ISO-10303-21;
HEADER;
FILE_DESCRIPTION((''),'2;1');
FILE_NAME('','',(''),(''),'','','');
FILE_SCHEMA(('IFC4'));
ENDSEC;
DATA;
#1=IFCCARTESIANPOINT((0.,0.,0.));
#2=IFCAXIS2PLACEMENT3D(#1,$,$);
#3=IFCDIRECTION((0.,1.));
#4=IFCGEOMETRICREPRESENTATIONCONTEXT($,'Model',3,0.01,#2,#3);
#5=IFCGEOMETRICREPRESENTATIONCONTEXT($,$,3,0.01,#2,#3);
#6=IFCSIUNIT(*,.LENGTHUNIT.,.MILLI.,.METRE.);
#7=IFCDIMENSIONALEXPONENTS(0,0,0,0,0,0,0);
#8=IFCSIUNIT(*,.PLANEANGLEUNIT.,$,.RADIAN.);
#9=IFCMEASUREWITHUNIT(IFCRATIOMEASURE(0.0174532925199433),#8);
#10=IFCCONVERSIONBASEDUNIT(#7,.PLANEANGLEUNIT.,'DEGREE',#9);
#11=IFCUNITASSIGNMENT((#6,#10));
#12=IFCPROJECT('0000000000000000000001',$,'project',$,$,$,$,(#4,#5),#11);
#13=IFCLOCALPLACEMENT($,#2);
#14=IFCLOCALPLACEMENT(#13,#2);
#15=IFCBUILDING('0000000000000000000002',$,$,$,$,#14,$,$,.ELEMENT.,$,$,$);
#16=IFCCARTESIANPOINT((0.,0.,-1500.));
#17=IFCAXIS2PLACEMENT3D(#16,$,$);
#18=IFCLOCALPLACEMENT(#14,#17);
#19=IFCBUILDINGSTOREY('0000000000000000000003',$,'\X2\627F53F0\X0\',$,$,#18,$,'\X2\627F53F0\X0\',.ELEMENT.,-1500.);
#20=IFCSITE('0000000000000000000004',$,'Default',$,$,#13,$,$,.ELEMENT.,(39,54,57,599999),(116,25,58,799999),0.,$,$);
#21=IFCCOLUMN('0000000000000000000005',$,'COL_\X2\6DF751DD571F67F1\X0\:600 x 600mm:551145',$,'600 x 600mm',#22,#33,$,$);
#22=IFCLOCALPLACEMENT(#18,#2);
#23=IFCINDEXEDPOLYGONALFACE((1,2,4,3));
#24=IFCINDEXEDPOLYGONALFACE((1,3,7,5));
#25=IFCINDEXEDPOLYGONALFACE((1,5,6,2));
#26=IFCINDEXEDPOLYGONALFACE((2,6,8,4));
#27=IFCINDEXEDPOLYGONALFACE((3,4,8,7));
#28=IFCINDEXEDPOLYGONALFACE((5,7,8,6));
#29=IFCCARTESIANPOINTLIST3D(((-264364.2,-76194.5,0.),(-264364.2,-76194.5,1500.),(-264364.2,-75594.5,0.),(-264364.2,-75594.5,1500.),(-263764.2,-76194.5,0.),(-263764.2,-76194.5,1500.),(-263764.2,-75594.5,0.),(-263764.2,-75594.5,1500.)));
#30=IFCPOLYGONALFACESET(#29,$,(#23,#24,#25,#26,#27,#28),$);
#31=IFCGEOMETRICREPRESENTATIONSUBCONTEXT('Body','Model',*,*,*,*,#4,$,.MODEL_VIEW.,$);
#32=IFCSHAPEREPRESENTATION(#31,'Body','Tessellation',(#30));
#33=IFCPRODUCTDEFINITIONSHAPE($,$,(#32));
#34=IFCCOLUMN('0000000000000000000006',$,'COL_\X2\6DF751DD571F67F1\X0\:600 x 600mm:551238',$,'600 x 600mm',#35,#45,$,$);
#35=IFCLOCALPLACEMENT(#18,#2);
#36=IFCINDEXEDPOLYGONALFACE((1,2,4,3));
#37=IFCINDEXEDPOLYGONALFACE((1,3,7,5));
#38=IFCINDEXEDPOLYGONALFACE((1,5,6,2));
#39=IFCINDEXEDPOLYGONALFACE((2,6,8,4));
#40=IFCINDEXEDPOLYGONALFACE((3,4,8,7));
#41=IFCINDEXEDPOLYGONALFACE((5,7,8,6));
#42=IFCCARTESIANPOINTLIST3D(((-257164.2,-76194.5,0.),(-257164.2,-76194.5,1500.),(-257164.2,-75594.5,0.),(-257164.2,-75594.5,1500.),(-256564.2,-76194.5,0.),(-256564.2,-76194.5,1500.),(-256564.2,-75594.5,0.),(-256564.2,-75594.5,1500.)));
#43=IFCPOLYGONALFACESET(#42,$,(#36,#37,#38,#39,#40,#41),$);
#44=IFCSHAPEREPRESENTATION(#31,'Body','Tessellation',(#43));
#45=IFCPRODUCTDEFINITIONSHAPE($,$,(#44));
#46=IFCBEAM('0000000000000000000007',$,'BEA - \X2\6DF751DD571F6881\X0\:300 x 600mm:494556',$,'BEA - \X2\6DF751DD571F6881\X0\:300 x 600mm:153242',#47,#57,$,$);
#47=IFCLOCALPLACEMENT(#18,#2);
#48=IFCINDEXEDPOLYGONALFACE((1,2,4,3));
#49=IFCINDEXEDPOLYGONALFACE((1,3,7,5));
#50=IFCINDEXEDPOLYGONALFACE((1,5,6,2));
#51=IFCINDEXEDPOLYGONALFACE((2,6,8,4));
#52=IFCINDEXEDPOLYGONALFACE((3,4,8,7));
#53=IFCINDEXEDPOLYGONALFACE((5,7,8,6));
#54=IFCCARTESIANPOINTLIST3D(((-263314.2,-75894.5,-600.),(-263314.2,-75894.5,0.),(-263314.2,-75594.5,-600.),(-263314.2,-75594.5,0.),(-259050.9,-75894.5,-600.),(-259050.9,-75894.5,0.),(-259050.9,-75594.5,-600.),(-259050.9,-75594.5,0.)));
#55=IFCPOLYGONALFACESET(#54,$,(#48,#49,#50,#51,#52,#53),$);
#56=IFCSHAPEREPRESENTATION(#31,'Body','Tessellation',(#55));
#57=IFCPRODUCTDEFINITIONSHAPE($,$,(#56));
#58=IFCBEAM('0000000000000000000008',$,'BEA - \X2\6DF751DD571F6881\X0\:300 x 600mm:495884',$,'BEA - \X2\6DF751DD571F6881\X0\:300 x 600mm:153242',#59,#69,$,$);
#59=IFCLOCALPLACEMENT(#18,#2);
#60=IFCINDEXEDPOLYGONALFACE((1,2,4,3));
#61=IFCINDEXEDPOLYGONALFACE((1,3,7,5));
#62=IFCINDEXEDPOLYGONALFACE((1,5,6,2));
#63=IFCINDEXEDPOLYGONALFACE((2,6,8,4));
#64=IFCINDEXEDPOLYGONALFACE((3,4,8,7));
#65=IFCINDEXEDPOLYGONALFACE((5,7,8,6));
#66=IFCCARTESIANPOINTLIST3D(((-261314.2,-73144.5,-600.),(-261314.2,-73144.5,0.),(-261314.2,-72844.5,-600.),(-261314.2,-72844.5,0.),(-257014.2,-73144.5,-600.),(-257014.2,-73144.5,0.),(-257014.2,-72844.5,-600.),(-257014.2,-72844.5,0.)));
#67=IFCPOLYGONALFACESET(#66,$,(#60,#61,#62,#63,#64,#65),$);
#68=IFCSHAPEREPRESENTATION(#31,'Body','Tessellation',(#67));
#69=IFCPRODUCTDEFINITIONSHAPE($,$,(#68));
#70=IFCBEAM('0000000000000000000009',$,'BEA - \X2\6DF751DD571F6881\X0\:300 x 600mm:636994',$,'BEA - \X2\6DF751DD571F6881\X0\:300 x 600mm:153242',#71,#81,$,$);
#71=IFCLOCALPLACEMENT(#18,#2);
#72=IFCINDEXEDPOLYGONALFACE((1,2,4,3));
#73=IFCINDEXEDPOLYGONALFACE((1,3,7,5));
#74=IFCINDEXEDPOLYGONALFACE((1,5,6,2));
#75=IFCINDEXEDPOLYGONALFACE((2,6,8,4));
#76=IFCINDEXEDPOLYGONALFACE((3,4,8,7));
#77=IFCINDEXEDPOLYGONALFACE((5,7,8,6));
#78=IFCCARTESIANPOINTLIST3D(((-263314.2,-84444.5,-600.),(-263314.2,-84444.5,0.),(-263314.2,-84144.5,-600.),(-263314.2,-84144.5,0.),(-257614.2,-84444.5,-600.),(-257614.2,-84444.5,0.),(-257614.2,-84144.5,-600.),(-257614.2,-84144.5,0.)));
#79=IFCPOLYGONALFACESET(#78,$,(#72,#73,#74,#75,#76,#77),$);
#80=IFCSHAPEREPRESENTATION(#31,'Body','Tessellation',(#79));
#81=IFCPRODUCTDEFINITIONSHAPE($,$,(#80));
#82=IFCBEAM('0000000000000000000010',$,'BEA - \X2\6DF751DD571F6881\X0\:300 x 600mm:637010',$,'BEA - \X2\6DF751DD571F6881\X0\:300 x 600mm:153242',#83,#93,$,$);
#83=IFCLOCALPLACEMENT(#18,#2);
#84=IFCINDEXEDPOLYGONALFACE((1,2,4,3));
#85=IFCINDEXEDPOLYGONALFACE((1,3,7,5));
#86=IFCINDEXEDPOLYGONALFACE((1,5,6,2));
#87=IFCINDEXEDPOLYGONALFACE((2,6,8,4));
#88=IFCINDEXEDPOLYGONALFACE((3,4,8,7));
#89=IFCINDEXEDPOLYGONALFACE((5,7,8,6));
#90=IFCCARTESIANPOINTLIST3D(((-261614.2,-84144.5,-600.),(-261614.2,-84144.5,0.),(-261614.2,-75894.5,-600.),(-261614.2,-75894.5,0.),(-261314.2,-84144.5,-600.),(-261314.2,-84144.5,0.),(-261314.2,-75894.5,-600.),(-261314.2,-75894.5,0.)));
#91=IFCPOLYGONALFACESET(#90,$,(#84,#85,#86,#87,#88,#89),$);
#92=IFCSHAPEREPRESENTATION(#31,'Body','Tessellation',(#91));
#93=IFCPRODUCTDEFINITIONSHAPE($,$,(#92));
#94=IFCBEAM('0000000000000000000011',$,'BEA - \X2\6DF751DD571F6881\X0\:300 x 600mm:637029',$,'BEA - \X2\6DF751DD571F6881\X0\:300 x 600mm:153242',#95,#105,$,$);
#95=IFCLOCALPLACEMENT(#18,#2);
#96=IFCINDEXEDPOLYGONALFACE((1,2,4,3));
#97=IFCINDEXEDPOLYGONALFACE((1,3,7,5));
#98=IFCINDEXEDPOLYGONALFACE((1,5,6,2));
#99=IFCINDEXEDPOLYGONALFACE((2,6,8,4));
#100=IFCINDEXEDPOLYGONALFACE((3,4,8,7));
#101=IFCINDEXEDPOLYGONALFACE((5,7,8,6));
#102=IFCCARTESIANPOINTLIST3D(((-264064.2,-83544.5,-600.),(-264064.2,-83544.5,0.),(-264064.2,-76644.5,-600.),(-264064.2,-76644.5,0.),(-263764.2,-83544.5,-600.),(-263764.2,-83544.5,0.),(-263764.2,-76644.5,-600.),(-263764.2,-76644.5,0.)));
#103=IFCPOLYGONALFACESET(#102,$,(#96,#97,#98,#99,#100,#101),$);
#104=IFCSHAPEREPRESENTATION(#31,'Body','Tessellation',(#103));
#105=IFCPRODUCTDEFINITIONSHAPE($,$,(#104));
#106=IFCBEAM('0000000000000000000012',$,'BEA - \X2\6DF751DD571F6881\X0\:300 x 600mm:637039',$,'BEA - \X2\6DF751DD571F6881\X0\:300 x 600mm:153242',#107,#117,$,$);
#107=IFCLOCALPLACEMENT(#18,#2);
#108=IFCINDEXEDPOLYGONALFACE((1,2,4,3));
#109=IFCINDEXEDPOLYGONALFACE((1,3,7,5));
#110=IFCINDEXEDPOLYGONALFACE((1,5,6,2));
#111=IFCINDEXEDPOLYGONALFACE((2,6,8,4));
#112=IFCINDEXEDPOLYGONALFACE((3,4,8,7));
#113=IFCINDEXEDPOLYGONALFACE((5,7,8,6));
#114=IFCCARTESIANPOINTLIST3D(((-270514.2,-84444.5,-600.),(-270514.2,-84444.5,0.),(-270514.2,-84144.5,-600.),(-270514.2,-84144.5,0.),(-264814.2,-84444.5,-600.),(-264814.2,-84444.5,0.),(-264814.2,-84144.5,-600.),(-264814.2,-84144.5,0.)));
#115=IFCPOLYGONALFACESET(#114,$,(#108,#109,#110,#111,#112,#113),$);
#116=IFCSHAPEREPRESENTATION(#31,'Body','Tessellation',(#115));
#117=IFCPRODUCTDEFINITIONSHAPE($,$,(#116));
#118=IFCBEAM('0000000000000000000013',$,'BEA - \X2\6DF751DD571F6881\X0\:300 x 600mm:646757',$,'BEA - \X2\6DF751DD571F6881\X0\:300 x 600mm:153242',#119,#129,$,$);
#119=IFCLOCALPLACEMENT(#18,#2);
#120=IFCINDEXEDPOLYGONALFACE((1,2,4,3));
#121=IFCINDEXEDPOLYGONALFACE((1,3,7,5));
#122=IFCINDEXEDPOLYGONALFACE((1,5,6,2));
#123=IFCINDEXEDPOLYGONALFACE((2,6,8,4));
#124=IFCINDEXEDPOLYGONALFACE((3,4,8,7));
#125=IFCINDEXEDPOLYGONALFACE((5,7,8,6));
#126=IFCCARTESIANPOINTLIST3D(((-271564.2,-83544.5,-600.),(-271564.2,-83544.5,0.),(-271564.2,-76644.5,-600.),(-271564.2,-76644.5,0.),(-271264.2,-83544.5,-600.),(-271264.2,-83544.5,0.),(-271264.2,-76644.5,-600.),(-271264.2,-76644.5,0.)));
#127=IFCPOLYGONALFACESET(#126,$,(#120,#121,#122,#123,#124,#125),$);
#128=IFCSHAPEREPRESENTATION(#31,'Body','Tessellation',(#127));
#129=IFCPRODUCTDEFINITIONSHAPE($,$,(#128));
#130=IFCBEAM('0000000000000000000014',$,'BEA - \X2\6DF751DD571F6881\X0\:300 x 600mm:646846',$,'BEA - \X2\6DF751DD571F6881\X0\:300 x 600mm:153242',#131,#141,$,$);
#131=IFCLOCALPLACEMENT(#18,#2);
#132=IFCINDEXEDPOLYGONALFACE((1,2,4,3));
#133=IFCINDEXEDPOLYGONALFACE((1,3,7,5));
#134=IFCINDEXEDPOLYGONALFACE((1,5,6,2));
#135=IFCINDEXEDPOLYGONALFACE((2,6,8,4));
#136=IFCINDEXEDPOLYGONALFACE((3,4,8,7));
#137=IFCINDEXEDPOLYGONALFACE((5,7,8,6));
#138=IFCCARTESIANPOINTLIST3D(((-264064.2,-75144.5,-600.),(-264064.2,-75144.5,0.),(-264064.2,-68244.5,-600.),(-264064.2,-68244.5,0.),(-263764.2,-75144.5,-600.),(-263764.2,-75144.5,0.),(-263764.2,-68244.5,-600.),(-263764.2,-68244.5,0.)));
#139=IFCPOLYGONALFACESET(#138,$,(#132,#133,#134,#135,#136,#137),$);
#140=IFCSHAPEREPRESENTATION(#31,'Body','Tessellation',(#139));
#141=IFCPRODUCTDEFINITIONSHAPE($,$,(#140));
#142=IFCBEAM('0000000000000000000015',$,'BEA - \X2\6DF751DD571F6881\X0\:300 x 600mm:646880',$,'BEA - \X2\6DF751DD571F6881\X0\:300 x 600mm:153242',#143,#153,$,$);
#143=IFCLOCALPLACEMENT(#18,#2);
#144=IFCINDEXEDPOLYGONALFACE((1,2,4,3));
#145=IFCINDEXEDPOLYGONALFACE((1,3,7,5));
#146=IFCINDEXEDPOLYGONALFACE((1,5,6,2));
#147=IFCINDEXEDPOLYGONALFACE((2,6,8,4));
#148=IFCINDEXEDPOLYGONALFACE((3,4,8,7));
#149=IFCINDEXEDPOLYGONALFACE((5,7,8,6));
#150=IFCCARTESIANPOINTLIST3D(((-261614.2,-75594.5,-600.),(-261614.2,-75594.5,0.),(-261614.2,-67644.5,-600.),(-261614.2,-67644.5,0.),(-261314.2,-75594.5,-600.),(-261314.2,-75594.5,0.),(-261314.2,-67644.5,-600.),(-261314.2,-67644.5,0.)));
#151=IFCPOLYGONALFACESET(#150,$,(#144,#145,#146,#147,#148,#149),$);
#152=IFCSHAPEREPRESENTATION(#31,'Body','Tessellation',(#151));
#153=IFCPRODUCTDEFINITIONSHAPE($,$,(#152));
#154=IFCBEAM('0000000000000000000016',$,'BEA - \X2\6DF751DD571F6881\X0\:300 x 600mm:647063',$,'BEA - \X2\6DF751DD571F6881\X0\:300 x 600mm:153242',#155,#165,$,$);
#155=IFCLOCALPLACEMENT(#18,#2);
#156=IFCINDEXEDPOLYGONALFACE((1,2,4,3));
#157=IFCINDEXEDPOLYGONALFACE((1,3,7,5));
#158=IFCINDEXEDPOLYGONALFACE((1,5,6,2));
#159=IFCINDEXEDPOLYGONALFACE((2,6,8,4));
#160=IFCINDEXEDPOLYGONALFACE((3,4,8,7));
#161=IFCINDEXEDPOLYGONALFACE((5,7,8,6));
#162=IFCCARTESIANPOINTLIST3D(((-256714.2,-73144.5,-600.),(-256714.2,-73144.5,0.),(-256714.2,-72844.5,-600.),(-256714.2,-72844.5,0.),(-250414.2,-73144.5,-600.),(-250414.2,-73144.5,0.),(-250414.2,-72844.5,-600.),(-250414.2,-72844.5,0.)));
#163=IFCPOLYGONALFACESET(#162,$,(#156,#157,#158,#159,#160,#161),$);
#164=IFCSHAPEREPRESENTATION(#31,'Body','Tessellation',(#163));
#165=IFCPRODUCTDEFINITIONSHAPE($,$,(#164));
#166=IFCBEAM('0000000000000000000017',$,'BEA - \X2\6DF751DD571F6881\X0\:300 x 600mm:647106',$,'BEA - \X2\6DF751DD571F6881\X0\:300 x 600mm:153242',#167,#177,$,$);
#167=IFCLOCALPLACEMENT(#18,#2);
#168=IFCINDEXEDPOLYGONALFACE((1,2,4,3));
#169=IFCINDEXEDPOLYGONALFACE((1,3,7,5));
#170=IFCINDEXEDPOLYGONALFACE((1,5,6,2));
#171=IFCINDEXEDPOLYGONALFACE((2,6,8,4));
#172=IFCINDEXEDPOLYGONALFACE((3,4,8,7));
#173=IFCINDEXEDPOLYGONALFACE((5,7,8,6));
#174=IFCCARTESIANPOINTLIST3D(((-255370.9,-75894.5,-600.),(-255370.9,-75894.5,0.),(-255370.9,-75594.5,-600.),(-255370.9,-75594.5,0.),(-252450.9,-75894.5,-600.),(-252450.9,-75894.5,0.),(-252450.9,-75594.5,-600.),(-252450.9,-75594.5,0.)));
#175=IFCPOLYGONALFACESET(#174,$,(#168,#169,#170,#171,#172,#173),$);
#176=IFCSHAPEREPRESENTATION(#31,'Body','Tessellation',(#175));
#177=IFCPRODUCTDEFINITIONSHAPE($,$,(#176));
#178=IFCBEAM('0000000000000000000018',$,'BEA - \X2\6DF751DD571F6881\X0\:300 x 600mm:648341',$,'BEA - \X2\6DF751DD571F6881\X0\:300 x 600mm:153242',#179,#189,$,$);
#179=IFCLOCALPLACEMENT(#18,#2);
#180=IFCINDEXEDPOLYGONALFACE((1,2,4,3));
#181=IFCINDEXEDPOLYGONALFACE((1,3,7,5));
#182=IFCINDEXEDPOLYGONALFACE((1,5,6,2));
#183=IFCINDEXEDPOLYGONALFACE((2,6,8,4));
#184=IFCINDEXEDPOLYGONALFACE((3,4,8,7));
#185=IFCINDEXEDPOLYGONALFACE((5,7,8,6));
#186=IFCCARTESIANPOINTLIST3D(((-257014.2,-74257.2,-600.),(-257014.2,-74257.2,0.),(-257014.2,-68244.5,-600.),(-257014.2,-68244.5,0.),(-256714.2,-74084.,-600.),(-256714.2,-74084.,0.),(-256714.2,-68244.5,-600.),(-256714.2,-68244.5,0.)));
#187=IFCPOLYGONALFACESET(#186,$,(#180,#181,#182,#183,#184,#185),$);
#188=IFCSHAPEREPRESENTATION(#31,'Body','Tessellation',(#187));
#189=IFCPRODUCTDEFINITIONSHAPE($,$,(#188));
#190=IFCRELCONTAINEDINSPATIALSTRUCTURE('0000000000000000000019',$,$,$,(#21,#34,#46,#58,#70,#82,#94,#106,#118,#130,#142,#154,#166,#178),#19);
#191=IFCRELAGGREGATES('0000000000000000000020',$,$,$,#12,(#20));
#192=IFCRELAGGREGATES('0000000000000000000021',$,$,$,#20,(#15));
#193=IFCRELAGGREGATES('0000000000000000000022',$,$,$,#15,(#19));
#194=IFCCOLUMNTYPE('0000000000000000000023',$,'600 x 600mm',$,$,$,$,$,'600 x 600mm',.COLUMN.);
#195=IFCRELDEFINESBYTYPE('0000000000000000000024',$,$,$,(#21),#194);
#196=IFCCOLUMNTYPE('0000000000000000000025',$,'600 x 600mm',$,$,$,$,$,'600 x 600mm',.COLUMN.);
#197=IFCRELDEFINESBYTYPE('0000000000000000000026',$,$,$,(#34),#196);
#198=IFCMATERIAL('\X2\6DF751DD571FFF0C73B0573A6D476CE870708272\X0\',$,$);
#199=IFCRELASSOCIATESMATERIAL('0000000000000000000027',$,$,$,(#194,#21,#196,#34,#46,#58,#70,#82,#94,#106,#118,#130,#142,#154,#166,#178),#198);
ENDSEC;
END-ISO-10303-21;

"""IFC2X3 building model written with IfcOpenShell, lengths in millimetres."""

from ifc_helpers import new_model, entity, si_unit, converted_unit, direction, frame, frame_2d, origin, origin_2d_with_axis, place, context, subcontext, project, spatial, rectangle, extrude, clip, halfspace, source, transform, mapped, material, type_object, type_shapes, element, save


model = new_model("IFC2X3")

# Units and contexts
model_context = context("Model", 3, precision=0.01, world=origin(), true_north=direction((0.0, 1.0)))
context_of_model = context(None, 3, precision=0.01, world=origin(), true_north=direction((0.0, 1.0)))
body_context = subcontext(model_context, "Body", "Model", "MODEL_VIEW")
ifc_project = project(units=[si_unit("LENGTHUNIT", "METRE", prefix="MILLI"), converted_unit("PLANEANGLEUNIT", "DEGREE", entity("IfcRatioMeasure", 0.0174532925199433), si_unit("PLANEANGLEUNIT", "RADIAN"), dimensions=[0, 0, 0, 0, 0, 0, 0])], contexts=[model_context, context_of_model])

# Site, building, storey
site_placement = place(None, origin())
site = spatial("IfcSite", under=ifc_project, at=site_placement, Name="Default", CompositionType="ELEMENT", RefLatitude=(39, 54, 57, 599999), RefLongitude=(116, 25, 58, 799999), RefElevation=0.0)
building_placement = place(site_placement, origin())
building = spatial("IfcBuilding", under=site, at=building_placement, CompositionType="ELEMENT")
storey_placement = place(building_placement, frame((0.0, 0.0, -1500.0)))
storey = spatial("IfcBuildingStorey", under=building, at=storey_placement, Name="承台", LongName="承台", CompositionType="ELEMENT", Elevation=-1500.0)

# Columns
ifc_material_1 = material(Name="混凝土，现场浇注灰色")
column_type_1 = type_object("IfcColumnType", Name="600 x 600mm", ElementType="600 x 600mm", PredefinedType="COLUMN", material=ifc_material_1)
shared_shape_1 = source(origin(), body_context, "Body", "SweptSolid", [
    extrude(rectangle(XDim=600.0, YDim=600.0, at=origin_2d_with_axis()), frame((300.0, 300.0, 0.0), z_axis=(0.0, 0.0, 1.0), x_axis=(-1.0, 0.0, 0.0)), (0.0, 0.0, 1.0), 1500.0),
])
type_shapes(column_type_1, [shared_shape_1])
column_1_placement = place(storey_placement, frame((-264364.2, -76194.5, 0.0)))
element("IfcColumn", 1, at=column_1_placement, inside=storey, type_object=column_type_1, material=ifc_material_1, Name="COL_混凝土柱:600 x 600mm:551145", ObjectType="600 x 600mm", context=body_context, shape_type="MappedRepresentation", body=[
    mapped(shared_shape_1, transform((0.0, 0.0, 0.0), scale=1.0)),
])
column_type_2 = type_object("IfcColumnType", Name="600 x 600mm", ElementType="600 x 600mm", PredefinedType="COLUMN", material=ifc_material_1)
shared_shape_2 = source(origin(), body_context, "Body", "SweptSolid", [
    extrude(rectangle(XDim=600.0, YDim=600.0, at=origin_2d_with_axis()), frame((300.0, 300.0, 0.0), z_axis=(0.0, 0.0, 1.0), x_axis=(-1.0, 0.0, 0.0)), (0.0, 0.0, 1.0), 1500.0),
])
type_shapes(column_type_2, [shared_shape_2])
column_2_placement = place(storey_placement, frame((-257164.2, -76194.5, 0.0)))
element("IfcColumn", 2, at=column_2_placement, inside=storey, type_object=column_type_2, material=ifc_material_1, Name="COL_混凝土柱:600 x 600mm:551238", ObjectType="600 x 600mm", context=body_context, shape_type="MappedRepresentation", body=[
    mapped(shared_shape_2, transform((0.0, 0.0, 0.0), scale=1.0)),
])

# Beams
beam_1_placement = place(storey_placement, frame((-263314.2, -75744.5, 0.0)))
element("IfcBeam", 3, at=beam_1_placement, inside=storey, material=ifc_material_1, Name="BEA - 混凝土梁:300 x 600mm:494556", ObjectType="BEA - 混凝土梁:300 x 600mm:153242", context=body_context, shape_type="SweptSolid", body=[
    extrude(rectangle(XDim=600.0, YDim=300.0, at=frame_2d((0.0, 0.0), x_axis=(1.0, 0.0))), frame((0.0, 0.0, -300.0), z_axis=(1.0, 0.0, 0.0), x_axis=(0.0, 0.0, -1.0)), (0.0, 0.0, 1.0), 4263.3),
])
beam_2_placement = place(storey_placement, frame((-261314.2, -72994.5, 0.0)))
element("IfcBeam", 4, at=beam_2_placement, inside=storey, material=ifc_material_1, Name="BEA - 混凝土梁:300 x 600mm:495884", ObjectType="BEA - 混凝土梁:300 x 600mm:153242", context=body_context, shape_type="SweptSolid", body=[
    extrude(rectangle(XDim=600.0, YDim=300.0, at=frame_2d((0.0, 0.0), x_axis=(1.0, 0.0))), frame((0.0, 0.0, -300.0), z_axis=(1.0, 0.0, 0.0), x_axis=(0.0, 0.0, -1.0)), (0.0, 0.0, 1.0), 4300.0),
])
beam_3_placement = place(storey_placement, frame((-257614.2, -84294.5, 0.0), z_axis=(0.0, 0.0, 1.0), x_axis=(-1.0, 0.0, 0.0)))
element("IfcBeam", 5, at=beam_3_placement, inside=storey, material=ifc_material_1, Name="BEA - 混凝土梁:300 x 600mm:636994", ObjectType="BEA - 混凝土梁:300 x 600mm:153242", context=body_context, shape_type="SweptSolid", body=[
    extrude(rectangle(XDim=600.0, YDim=300.0, at=frame_2d((0.0, 0.0), x_axis=(1.0, 0.0))), frame((0.0, 0.0, -300.0), z_axis=(1.0, 0.0, 0.0), x_axis=(0.0, 0.0, -1.0)), (0.0, 0.0, 1.0), 5700.0),
])
beam_4_placement = place(storey_placement, frame((-261464.2, -84144.5, 0.0), z_axis=(0.0, 0.0, 1.0), x_axis=(0.0, 1.0, 0.0)))
element("IfcBeam", 6, at=beam_4_placement, inside=storey, material=ifc_material_1, Name="BEA - 混凝土梁:300 x 600mm:637010", ObjectType="BEA - 混凝土梁:300 x 600mm:153242", context=body_context, shape_type="SweptSolid", body=[
    extrude(rectangle(XDim=600.0, YDim=300.0, at=origin_2d_with_axis()), frame((0.0, 0.0, -300.0), z_axis=(1.0, 0.0, 0.0), x_axis=(0.0, 0.0, -1.0)), (0.0, 0.0, 1.0), 8250.0),
])
beam_5_placement = place(storey_placement, frame((-263914.2, -83544.5, 0.0), z_axis=(0.0, 0.0, 1.0), x_axis=(0.0, 1.0, 0.0)))
element("IfcBeam", 7, at=beam_5_placement, inside=storey, material=ifc_material_1, Name="BEA - 混凝土梁:300 x 600mm:637029", ObjectType="BEA - 混凝土梁:300 x 600mm:153242", context=body_context, shape_type="SweptSolid", body=[
    extrude(rectangle(XDim=600.0, YDim=300.0, at=origin_2d_with_axis()), frame((0.0, 0.0, -300.0), z_axis=(1.0, 0.0, 0.0), x_axis=(0.0, 0.0, -1.0)), (0.0, 0.0, 1.0), 6900.0),
])
beam_6_placement = place(storey_placement, frame((-264814.2, -84294.5, 0.0), z_axis=(0.0, 0.0, 1.0), x_axis=(-1.0, 0.0, 0.0)))
element("IfcBeam", 8, at=beam_6_placement, inside=storey, material=ifc_material_1, Name="BEA - 混凝土梁:300 x 600mm:637039", ObjectType="BEA - 混凝土梁:300 x 600mm:153242", context=body_context, shape_type="SweptSolid", body=[
    extrude(rectangle(XDim=600.0, YDim=300.0, at=frame_2d((0.0, 0.0), x_axis=(1.0, 0.0))), frame((0.0, 0.0, -300.0), z_axis=(1.0, 0.0, 0.0), x_axis=(0.0, 0.0, -1.0)), (0.0, 0.0, 1.0), 5700.0),
])
for number, where, z_axis, x_axis, name in (
    (9, (-271414.2, -76644.5, 0.0), (0.0, 0.0, 1.0), (0.0, -1.0, 0.0), "BEA - 混凝土梁:300 x 600mm:646757"),
    (10, (-263914.2, -75144.5, 0.0), (0.0, 0.0, 1.0), (0.0, 1.0, 0.0), "BEA - 混凝土梁:300 x 600mm:646846"),
):
    element("IfcBeam", number, at=place(storey_placement, frame(where, z_axis=z_axis, x_axis=x_axis)), inside=storey, material=ifc_material_1, Name=name, ObjectType="BEA - 混凝土梁:300 x 600mm:153242", context=body_context, shape_type="SweptSolid", body=[
        extrude(rectangle(XDim=600.0, YDim=300.0, at=origin_2d_with_axis()), frame((0.0, 0.0, -300.0), z_axis=(1.0, 0.0, 0.0), x_axis=(0.0, 0.0, -1.0)), (0.0, 0.0, 1.0), 6900.0),
    ])
beam_7_placement = place(storey_placement, frame((-261464.2, -75594.5, 0.0), z_axis=(0.0, 0.0, 1.0), x_axis=(0.0, 1.0, 0.0)))
element("IfcBeam", 11, at=beam_7_placement, inside=storey, material=ifc_material_1, Name="BEA - 混凝土梁:300 x 600mm:646880", ObjectType="BEA - 混凝土梁:300 x 600mm:153242", context=body_context, shape_type="SweptSolid", body=[
    extrude(rectangle(XDim=600.0, YDim=300.0, at=origin_2d_with_axis()), frame((0.0, 0.0, -300.0), z_axis=(1.0, 0.0, 0.0), x_axis=(0.0, 0.0, -1.0)), (0.0, 0.0, 1.0), 7950.0),
])
beam_8_placement = place(storey_placement, frame((-256714.2, -72994.5, 0.0)))
element("IfcBeam", 12, at=beam_8_placement, inside=storey, material=ifc_material_1, Name="BEA - 混凝土梁:300 x 600mm:647063", ObjectType="BEA - 混凝土梁:300 x 600mm:153242", context=body_context, shape_type="SweptSolid", body=[
    extrude(rectangle(XDim=600.0, YDim=300.0, at=frame_2d((0.0, 0.0), x_axis=(1.0, 0.0))), frame((0.0, 0.0, -300.0), z_axis=(1.0, 0.0, 0.0), x_axis=(0.0, 0.0, -1.0)), (0.0, 0.0, 1.0), 6300.0),
])
beam_9_placement = place(storey_placement, frame((-255370.9, -75744.5, 0.0)))
element("IfcBeam", 13, at=beam_9_placement, inside=storey, material=ifc_material_1, Name="BEA - 混凝土梁:300 x 600mm:647106", ObjectType="BEA - 混凝土梁:300 x 600mm:153242", context=body_context, shape_type="SweptSolid", body=[
    extrude(rectangle(XDim=600.0, YDim=300.0, at=frame_2d((0.0, 0.0), x_axis=(1.0, 0.0))), frame((0.0, 0.0, -300.0), z_axis=(1.0, 0.0, 0.0), x_axis=(0.0, 0.0, -1.0)), (0.0, 0.0, 1.0), 2920.0),
])
beam_10_placement = place(storey_placement, frame((-256864.2, -68244.5, 0.0), z_axis=(0.0, 0.0, 1.0), x_axis=(0.0, -1.0, 0.0)))
element("IfcBeam", 14, at=beam_10_placement, inside=storey, material=ifc_material_1, Name="BEA - 混凝土梁:300 x 600mm:648341", ObjectType="BEA - 混凝土梁:300 x 600mm:153242", context=body_context, shape_type="Clipping", body=[
    clip(extrude(rectangle(XDim=600.0, YDim=300.0, at=frame_2d((0.0, 0.0), x_axis=(1.0, 0.0))), frame((0.0, 0.0, -300.0), z_axis=(1.0, 0.0, 0.0), x_axis=(0.0, 0.0, -1.0)), (0.0, 0.0, 1.0), 6012.7), halfspace(frame((5526.0, 693.3, 0.0), z_axis=(0.866125, 0.499827, 0.0), x_axis=(-0.499827, 0.866125, 0.0)), False)),
])

save(model, "model.ifc")
